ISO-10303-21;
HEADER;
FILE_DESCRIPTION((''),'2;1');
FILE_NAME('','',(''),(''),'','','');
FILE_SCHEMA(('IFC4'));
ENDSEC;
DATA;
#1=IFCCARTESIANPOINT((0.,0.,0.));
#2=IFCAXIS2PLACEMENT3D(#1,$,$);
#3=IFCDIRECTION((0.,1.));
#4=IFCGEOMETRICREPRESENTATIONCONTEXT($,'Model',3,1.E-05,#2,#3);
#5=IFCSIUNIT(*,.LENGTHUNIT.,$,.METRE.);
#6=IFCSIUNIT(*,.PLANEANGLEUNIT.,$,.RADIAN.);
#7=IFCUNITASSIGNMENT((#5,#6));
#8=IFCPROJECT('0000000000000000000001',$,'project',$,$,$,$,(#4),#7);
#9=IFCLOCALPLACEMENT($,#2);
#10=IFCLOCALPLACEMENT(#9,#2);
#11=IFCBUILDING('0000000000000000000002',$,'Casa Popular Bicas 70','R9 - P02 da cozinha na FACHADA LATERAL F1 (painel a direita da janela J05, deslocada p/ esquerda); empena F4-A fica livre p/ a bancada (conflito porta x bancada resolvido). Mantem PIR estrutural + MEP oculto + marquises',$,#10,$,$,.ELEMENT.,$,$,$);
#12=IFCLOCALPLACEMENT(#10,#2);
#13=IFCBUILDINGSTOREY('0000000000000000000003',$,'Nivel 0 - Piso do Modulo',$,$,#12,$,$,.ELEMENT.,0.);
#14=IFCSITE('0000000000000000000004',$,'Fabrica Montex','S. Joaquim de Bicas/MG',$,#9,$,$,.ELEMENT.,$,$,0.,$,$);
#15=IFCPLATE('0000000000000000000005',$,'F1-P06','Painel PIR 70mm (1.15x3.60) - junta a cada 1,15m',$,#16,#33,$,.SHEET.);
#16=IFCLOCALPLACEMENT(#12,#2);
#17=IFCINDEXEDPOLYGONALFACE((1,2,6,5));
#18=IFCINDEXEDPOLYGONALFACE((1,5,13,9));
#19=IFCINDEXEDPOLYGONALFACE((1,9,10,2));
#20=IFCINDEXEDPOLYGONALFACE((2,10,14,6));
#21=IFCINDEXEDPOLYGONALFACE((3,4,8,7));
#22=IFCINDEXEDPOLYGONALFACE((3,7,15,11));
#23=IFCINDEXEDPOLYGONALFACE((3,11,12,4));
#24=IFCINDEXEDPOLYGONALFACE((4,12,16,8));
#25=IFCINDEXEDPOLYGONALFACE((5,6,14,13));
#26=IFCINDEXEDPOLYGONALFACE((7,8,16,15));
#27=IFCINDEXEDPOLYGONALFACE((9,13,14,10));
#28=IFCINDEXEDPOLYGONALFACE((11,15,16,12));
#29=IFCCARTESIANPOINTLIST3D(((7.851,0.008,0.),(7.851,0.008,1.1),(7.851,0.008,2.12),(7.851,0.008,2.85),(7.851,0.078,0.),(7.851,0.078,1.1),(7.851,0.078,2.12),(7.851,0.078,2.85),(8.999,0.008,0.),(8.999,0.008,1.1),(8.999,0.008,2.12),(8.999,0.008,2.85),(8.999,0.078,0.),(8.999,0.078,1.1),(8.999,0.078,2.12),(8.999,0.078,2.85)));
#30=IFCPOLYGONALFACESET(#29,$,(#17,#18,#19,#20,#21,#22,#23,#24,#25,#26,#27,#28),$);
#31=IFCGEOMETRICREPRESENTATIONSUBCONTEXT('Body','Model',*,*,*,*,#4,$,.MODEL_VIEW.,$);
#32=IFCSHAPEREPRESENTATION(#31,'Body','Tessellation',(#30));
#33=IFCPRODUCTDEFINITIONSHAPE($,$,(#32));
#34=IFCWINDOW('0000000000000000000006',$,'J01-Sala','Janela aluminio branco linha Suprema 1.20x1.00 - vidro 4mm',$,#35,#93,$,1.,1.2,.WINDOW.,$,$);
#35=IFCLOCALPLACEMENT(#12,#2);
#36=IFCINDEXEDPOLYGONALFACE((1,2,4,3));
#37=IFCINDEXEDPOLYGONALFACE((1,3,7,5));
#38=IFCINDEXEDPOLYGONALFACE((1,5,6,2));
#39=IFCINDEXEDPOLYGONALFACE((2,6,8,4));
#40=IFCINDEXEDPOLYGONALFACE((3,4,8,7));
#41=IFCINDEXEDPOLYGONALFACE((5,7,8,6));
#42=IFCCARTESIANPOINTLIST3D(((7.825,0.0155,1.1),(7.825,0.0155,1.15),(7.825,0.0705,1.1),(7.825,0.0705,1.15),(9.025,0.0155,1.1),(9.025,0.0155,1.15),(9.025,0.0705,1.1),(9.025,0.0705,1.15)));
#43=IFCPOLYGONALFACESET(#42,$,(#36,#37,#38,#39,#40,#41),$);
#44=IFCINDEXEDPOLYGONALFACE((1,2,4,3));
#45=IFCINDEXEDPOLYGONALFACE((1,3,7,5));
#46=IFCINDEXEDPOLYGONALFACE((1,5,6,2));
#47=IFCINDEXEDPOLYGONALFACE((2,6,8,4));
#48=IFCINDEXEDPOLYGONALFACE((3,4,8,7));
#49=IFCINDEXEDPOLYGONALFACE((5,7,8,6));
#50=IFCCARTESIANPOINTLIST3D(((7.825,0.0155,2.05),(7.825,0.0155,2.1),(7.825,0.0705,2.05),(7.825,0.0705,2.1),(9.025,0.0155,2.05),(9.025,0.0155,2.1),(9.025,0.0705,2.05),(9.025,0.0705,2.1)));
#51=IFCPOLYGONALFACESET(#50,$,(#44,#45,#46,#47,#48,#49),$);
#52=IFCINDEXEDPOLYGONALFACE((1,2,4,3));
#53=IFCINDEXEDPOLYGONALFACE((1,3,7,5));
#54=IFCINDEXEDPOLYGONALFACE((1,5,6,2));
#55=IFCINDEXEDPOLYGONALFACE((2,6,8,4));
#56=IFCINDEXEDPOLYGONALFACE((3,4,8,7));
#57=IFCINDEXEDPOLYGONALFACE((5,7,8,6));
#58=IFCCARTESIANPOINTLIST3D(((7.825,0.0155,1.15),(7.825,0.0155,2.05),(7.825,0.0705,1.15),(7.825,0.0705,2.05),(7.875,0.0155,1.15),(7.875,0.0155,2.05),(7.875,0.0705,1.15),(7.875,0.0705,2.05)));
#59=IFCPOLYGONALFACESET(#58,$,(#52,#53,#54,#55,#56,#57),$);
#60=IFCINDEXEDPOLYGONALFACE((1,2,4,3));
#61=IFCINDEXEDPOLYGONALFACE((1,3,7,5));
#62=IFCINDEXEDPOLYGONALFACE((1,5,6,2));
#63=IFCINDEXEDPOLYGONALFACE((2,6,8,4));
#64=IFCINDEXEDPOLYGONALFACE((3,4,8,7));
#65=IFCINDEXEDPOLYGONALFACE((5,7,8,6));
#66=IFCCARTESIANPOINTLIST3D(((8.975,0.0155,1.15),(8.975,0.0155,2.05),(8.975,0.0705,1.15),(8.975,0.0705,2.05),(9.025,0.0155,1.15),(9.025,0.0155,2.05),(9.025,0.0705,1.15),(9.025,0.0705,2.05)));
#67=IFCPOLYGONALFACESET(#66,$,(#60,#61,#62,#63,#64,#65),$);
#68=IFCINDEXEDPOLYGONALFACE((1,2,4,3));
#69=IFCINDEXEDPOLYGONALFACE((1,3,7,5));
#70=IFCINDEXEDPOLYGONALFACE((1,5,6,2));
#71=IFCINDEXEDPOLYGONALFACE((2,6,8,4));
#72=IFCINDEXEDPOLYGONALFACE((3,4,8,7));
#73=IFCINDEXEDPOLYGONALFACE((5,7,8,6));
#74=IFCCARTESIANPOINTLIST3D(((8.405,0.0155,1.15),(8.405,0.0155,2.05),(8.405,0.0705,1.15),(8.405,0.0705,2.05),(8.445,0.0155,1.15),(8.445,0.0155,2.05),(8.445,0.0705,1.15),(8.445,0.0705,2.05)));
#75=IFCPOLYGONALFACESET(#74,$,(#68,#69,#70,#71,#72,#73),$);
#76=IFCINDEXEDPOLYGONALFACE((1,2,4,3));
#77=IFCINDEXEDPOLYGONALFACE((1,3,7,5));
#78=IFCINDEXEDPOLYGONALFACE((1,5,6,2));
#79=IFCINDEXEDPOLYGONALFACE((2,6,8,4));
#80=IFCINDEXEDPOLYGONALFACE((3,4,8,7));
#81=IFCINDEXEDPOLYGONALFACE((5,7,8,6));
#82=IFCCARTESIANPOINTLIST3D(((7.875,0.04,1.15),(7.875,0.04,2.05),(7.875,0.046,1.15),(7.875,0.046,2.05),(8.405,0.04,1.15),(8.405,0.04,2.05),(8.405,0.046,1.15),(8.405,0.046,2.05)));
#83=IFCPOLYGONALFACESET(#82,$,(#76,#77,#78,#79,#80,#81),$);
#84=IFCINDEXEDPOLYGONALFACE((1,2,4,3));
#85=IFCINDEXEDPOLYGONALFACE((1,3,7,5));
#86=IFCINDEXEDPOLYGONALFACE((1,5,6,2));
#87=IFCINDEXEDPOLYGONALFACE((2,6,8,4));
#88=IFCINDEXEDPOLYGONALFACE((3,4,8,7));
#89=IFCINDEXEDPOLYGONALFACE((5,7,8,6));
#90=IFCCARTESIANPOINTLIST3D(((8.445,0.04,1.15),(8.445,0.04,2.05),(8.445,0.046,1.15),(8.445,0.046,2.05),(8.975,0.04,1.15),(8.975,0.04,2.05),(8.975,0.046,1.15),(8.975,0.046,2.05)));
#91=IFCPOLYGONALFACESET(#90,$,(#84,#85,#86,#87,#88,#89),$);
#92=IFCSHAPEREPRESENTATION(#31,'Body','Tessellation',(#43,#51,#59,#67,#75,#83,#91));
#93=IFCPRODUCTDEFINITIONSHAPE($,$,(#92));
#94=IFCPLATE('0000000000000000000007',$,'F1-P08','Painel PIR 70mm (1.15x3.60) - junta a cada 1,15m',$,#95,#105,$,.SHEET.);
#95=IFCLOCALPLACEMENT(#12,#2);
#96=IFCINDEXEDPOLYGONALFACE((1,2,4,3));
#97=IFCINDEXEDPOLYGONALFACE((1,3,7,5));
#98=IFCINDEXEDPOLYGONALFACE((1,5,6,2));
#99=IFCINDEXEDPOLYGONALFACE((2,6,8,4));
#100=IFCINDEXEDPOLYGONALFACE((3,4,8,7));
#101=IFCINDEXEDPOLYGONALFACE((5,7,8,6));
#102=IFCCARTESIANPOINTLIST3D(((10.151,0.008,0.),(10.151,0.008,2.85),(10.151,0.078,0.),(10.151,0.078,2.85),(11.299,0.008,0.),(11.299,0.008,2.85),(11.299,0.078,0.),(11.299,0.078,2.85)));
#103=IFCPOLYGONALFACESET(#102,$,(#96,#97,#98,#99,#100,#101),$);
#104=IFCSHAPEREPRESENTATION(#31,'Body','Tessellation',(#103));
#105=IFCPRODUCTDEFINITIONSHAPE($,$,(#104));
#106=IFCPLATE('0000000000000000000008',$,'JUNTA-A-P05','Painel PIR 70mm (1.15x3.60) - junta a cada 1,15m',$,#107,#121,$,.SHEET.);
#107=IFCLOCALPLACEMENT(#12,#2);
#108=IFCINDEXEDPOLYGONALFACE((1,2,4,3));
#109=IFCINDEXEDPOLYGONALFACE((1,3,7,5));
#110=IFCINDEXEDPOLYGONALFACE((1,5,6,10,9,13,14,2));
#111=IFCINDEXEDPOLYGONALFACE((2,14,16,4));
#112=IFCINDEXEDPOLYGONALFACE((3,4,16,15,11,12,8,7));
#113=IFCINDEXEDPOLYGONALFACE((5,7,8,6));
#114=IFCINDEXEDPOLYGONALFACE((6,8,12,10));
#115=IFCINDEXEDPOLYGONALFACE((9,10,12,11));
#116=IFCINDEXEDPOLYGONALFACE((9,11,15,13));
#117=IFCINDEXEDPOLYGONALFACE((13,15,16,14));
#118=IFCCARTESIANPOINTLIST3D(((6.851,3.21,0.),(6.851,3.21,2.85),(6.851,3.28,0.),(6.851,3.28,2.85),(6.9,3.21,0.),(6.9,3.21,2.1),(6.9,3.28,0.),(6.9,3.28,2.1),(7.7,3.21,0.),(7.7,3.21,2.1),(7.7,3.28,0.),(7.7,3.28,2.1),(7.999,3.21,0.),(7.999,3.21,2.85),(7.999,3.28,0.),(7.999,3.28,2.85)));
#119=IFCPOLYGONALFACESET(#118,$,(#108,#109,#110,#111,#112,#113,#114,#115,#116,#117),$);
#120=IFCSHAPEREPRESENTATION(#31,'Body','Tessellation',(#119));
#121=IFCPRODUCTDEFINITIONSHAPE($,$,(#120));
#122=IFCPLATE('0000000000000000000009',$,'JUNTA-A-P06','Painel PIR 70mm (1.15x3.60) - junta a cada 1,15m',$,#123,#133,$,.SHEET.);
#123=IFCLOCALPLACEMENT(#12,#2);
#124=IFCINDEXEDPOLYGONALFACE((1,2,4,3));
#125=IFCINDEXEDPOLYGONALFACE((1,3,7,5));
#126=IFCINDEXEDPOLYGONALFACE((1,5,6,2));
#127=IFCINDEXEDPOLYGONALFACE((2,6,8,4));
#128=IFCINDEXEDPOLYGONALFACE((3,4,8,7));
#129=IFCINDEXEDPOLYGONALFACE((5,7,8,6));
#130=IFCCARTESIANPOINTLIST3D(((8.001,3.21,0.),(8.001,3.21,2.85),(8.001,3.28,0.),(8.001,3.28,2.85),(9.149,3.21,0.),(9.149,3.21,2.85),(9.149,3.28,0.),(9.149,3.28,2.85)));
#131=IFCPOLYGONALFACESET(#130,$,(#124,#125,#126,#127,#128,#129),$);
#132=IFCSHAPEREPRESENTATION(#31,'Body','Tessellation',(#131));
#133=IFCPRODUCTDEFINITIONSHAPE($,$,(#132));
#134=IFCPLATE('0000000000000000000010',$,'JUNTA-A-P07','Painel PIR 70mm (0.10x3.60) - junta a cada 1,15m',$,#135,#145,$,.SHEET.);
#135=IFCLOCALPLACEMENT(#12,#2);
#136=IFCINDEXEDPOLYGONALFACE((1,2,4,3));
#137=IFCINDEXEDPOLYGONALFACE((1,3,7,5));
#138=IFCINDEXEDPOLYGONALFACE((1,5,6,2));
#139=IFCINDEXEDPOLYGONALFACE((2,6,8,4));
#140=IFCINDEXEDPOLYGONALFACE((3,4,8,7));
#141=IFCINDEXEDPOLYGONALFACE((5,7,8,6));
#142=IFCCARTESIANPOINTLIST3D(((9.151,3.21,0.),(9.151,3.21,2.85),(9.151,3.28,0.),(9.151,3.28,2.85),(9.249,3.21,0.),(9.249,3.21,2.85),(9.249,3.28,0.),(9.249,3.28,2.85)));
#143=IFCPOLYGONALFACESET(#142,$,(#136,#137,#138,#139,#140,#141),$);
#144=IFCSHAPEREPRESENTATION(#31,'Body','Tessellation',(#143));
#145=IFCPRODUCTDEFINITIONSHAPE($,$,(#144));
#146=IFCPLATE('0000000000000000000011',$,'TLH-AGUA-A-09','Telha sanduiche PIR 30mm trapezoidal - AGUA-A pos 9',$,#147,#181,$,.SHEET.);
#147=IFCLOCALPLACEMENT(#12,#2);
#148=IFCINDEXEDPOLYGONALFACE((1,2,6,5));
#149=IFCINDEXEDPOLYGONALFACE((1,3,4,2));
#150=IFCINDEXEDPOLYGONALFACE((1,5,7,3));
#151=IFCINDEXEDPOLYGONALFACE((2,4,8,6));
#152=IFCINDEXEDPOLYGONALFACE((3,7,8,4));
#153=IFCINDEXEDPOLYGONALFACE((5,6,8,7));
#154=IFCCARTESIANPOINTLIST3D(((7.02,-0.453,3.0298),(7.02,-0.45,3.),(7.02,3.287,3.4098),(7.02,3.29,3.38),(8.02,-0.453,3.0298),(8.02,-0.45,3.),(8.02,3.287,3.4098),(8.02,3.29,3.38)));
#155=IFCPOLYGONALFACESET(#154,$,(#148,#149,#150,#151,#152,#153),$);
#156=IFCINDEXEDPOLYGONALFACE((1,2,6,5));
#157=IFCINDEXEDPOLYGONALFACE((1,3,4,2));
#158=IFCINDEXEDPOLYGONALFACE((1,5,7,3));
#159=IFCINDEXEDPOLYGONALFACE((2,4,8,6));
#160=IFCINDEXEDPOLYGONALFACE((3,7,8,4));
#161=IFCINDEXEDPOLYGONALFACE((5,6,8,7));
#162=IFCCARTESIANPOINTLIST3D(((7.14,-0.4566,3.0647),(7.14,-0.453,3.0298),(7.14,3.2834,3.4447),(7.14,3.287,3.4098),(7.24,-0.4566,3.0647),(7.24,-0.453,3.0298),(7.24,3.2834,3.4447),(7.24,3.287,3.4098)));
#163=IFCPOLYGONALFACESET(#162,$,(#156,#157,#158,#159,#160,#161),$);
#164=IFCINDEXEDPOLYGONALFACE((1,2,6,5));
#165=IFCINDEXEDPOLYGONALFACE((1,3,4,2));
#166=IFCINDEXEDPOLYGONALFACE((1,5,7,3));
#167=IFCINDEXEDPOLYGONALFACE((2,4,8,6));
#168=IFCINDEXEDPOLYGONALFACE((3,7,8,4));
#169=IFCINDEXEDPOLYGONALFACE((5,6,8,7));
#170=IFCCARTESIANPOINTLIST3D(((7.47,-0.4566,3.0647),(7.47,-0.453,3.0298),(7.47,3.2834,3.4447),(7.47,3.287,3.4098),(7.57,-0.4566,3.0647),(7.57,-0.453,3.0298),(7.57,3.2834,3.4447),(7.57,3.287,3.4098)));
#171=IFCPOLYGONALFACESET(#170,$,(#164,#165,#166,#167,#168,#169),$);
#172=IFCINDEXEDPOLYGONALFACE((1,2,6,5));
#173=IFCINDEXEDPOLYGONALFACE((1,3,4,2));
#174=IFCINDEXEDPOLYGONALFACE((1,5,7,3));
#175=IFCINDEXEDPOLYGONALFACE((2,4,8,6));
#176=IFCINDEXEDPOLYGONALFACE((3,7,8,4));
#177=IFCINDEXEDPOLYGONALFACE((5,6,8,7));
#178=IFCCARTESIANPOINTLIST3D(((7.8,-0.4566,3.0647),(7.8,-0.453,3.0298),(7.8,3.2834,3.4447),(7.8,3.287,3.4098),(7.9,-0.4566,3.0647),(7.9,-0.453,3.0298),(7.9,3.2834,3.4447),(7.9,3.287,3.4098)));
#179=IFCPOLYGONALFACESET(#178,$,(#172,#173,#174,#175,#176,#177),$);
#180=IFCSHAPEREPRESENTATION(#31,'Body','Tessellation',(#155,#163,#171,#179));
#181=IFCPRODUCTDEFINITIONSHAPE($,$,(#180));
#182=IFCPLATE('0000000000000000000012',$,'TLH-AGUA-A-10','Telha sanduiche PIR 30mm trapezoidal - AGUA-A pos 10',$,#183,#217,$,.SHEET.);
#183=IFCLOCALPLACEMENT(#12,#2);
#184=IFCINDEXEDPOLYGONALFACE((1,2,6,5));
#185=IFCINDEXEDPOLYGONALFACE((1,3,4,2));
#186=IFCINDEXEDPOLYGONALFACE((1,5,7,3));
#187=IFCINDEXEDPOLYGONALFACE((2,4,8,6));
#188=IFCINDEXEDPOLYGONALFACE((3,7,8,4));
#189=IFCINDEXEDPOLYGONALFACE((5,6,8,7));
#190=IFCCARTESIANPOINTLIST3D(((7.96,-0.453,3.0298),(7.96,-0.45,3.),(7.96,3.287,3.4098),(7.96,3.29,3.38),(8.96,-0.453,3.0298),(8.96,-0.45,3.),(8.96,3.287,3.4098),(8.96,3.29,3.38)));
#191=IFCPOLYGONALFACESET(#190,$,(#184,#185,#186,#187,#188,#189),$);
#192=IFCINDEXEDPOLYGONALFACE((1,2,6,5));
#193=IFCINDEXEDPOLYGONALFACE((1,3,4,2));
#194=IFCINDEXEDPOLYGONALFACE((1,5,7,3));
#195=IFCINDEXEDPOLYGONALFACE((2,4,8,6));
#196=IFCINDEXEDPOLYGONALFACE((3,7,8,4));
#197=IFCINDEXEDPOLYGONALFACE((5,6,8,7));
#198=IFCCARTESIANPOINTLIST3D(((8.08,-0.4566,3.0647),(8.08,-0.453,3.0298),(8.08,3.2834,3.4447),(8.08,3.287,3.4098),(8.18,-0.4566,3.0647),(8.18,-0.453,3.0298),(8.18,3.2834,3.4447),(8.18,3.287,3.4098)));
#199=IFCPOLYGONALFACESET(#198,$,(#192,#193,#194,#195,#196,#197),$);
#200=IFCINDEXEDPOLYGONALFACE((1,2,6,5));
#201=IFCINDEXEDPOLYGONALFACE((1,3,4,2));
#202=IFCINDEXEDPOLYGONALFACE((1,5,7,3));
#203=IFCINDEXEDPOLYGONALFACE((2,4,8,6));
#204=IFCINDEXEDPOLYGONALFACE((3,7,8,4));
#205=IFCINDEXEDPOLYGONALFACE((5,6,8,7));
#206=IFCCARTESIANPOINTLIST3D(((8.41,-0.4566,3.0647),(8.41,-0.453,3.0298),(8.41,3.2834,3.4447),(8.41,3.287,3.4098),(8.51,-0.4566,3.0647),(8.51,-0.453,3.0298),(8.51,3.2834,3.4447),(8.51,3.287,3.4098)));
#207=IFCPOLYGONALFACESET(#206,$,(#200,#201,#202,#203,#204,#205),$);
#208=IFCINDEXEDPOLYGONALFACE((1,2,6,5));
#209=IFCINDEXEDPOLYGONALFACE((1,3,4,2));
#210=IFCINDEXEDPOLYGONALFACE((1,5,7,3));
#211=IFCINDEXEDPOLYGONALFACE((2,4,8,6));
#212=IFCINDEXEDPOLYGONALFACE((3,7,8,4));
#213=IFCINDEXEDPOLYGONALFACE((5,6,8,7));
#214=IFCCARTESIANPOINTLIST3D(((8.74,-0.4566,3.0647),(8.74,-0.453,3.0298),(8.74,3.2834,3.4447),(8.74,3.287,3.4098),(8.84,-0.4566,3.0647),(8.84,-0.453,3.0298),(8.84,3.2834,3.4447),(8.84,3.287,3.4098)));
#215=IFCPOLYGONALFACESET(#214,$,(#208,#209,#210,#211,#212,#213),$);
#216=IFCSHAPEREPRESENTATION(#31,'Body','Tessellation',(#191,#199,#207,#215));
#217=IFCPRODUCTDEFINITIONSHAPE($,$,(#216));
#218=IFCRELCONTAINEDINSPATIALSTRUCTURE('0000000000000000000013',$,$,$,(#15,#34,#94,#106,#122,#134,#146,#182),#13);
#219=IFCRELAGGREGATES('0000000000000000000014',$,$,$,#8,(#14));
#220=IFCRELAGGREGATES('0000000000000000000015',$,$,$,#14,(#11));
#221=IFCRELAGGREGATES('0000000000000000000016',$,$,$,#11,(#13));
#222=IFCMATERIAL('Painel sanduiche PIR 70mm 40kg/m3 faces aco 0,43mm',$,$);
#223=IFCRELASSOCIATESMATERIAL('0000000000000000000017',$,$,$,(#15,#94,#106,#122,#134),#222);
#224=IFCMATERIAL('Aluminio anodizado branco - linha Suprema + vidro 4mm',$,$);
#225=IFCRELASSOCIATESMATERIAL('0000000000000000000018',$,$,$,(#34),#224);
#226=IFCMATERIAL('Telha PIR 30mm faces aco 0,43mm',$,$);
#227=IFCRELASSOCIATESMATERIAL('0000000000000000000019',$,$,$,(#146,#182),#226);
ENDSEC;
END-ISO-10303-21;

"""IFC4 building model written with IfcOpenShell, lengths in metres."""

from ifc_helpers import new_model, si_unit, direction, frame, frame_2d, origin, origin_2d, place, context, subcontext, project, spatial, rectangle, extrude, material, element, fill, save


model = new_model("IFC4")

# Units and contexts
model_context = context("Model", 3, precision=1e-05, world=origin(), true_north=direction((0.0, 1.0)))
body_context = subcontext(model_context, "Body", "Model", "MODEL_VIEW")
ifc_project = project(units=[si_unit("LENGTHUNIT", "METRE"), si_unit("PLANEANGLEUNIT", "RADIAN")], contexts=[model_context])

# Site, building, storey
site_placement = place(None, origin())
site = spatial("IfcSite", under=ifc_project, at=site_placement, Name="Fabrica Montex", Description="S. Joaquim de Bicas/MG", CompositionType="ELEMENT", RefElevation=0.0)
building_placement = place(site_placement, origin())
building = spatial("IfcBuilding", under=site, at=building_placement, Name="Casa Popular Bicas 70", Description="R9 - P02 da cozinha na FACHADA LATERAL F1 (painel a direita da janela J05, deslocada p/ esquerda); empena F4-A fica livre p/ a bancada (conflito porta x bancada resolvido). Mantem PIR estrutural + MEP oculto + marquises", CompositionType="ELEMENT")
storey_placement = place(building_placement, origin())
storey = spatial("IfcBuildingStorey", under=building, at=storey_placement, Name="Nivel 0 - Piso do Modulo", CompositionType="ELEMENT", Elevation=0.0)

# Shared definitions
ifc_material_1 = material(Name="Painel sanduiche PIR 70mm 40kg/m3 faces aco 0,43mm")

# Plate, opening, window
plate_1_placement = place(storey_placement, frame((7.851, 0.043, 0.0), x_axis=(1.0, 0.0, 0.0)))
plate_1 = element("IfcPlate", 1, at=plate_1_placement, inside=storey, material=ifc_material_1, Name="F1-P06", Description="Painel PIR 70mm (1.15x3.60) - junta a cada 1,15m", PredefinedType="SHEET", context=body_context, shape_type="SweptSolid", body=[
    extrude(rectangle(XDim=1.148, YDim=0.07, at=frame_2d((0.574, 0.0))), origin(), (0.0, 0.0, 1.0), 2.85),
])
opening_1_placement = place(storey_placement, frame((7.825, 0.043, 1.1)))
opening_1 = element("IfcOpeningElement", 2, at=opening_1_placement, cuts=plate_1, PredefinedType="OPENING", context=body_context, shape_type="SweptSolid", body=[
    extrude(rectangle(XDim=1.22, YDim=0.3, at=frame_2d((0.6, 0.0))), origin(), (0.0, 0.0, 1.0), 1.02),
])
ifc_material_2 = material(Name="Aluminio anodizado branco - linha Suprema + vidro 4mm")
window_placement = place(storey_placement, frame((7.825, 0.043, 1.1), x_axis=(1.0, 0.0, 0.0)))
window = element("IfcWindow", 3, at=window_placement, inside=storey, material=ifc_material_2, Name="J01-Sala", Description="Janela aluminio branco linha Suprema 1.20x1.00 - vidro 4mm", OverallHeight=1.0, OverallWidth=1.2, PredefinedType="WINDOW", context=body_context, shape_type="SweptSolid", body=[
    extrude(rectangle(XDim=1.2, YDim=0.055, at=frame_2d((0.6, 0.0))), origin(), (0.0, 0.0, 1.0), 0.05),
    extrude(rectangle(XDim=1.2, YDim=0.055, at=frame_2d((0.6, 0.0))), frame((0.0, 0.0, 0.95)), (0.0, 0.0, 1.0), 0.05),
    extrude(rectangle(XDim=0.05, YDim=0.055, at=frame_2d((0.025, 0.0))), frame((0.0, 0.0, 0.05)), (0.0, 0.0, 1.0), 0.9),
    extrude(rectangle(XDim=0.05, YDim=0.055, at=frame_2d((1.175, 0.0))), frame((0.0, 0.0, 0.05)), (0.0, 0.0, 1.0), 0.9),
    extrude(rectangle(XDim=0.04, YDim=0.055, at=frame_2d((0.6, 0.0))), frame((0.0, 0.0, 0.05)), (0.0, 0.0, 1.0), 0.9),
    extrude(rectangle(XDim=0.53, YDim=0.006, at=frame_2d((0.315, 0.0))), frame((0.0, 0.0, 0.05)), (0.0, 0.0, 1.0), 0.9),
    extrude(rectangle(XDim=0.53, YDim=0.006, at=frame_2d((0.885, 0.0))), frame((0.0, 0.0, 0.05)), (0.0, 0.0, 1.0), 0.9),
])
fill(opening_1, window)

# Plate
plate_2_placement = place(storey_placement, frame((10.151, 0.043, 0.0), x_axis=(1.0, 0.0, 0.0)))
element("IfcPlate", 4, at=plate_2_placement, inside=storey, material=ifc_material_1, Name="F1-P08", Description="Painel PIR 70mm (1.15x3.60) - junta a cada 1,15m", PredefinedType="SHEET", context=body_context, shape_type="SweptSolid", body=[
    extrude(rectangle(XDim=1.148, YDim=0.07, at=frame_2d((0.574, 0.0))), origin(), (0.0, 0.0, 1.0), 2.85),
])

# Plate, opening
plate_3_placement = place(storey_placement, frame((6.851, 3.245, 0.0), x_axis=(1.0, 0.0, 0.0)))
plate_3 = element("IfcPlate", 5, at=plate_3_placement, inside=storey, material=ifc_material_1, Name="JUNTA-A-P05", Description="Painel PIR 70mm (1.15x3.60) - junta a cada 1,15m", PredefinedType="SHEET", context=body_context, shape_type="SweptSolid", body=[
    extrude(rectangle(XDim=1.148, YDim=0.07, at=frame_2d((0.574, 0.0))), origin(), (0.0, 0.0, 1.0), 2.85),
])
opening_2_placement = place(storey_placement, frame((7.3, 3.245, 0.0)))
element("IfcOpeningElement", 6, at=opening_2_placement, cuts=plate_3, PredefinedType="OPENING", context=body_context, shape_type="SweptSolid", body=[
    extrude(rectangle(XDim=0.8, YDim=0.1, at=origin_2d()), origin(), (0.0, 0.0, 1.0), 2.1),
])

# Plates
plate_4_placement = place(storey_placement, frame((8.001, 3.245, 0.0), x_axis=(1.0, 0.0, 0.0)))
element("IfcPlate", 7, at=plate_4_placement, inside=storey, material=ifc_material_1, Name="JUNTA-A-P06", Description="Painel PIR 70mm (1.15x3.60) - junta a cada 1,15m", PredefinedType="SHEET", context=body_context, shape_type="SweptSolid", body=[
    extrude(rectangle(XDim=1.148, YDim=0.07, at=frame_2d((0.574, 0.0))), origin(), (0.0, 0.0, 1.0), 2.85),
])
plate_5_placement = place(storey_placement, frame((9.151, 3.245, 0.0), x_axis=(1.0, 0.0, 0.0)))
element("IfcPlate", 8, at=plate_5_placement, inside=storey, material=ifc_material_1, Name="JUNTA-A-P07", Description="Painel PIR 70mm (0.10x3.60) - junta a cada 1,15m", PredefinedType="SHEET", context=body_context, shape_type="SweptSolid", body=[
    extrude(rectangle(XDim=0.098, YDim=0.07, at=frame_2d((0.049, 0.0))), origin(), (0.0, 0.0, 1.0), 2.85),
])
ifc_material_3 = material(Name="Telha PIR 30mm faces aco 0,43mm")
for number, where, z_axis, x_axis, name, description in (
    (9, (7.02, -0.45, 3.0), (0.0, -0.101084, 0.994878), (1.0, 0.0, 0.0), "TLH-AGUA-A-09", "Telha sanduiche PIR 30mm trapezoidal - AGUA-A pos 9"),
    (10, (7.96, -0.45, 3.0), (0.0, -0.101084, 0.994878), (1.0, 0.0, 0.0), "TLH-AGUA-A-10", "Telha sanduiche PIR 30mm trapezoidal - AGUA-A pos 10"),
):
    element("IfcPlate", number, at=place(storey_placement, frame(where, z_axis=z_axis, x_axis=x_axis)), inside=storey, material=ifc_material_3, Name=name, Description=description, PredefinedType="SHEET", context=body_context, shape_type="SweptSolid", body=[
        extrude(rectangle(XDim=1.0, YDim=3.7593, at=frame_2d((0.5, 1.8796))), origin(), (0.0, 0.0, 1.0), 0.03),
        extrude(rectangle(XDim=0.1, YDim=3.7593, at=frame_2d((0.17, 1.8796))), frame((0.0, 0.0, 0.03)), (0.0, 0.0, 1.0), 0.035),
        extrude(rectangle(XDim=0.1, YDim=3.7593, at=frame_2d((0.5, 1.8796))), frame((0.0, 0.0, 0.03)), (0.0, 0.0, 1.0), 0.035),
        extrude(rectangle(XDim=0.1, YDim=3.7593, at=frame_2d((0.83, 1.8796))), frame((0.0, 0.0, 0.03)), (0.0, 0.0, 1.0), 0.035),
    ])

save(model, "model.ifc")
